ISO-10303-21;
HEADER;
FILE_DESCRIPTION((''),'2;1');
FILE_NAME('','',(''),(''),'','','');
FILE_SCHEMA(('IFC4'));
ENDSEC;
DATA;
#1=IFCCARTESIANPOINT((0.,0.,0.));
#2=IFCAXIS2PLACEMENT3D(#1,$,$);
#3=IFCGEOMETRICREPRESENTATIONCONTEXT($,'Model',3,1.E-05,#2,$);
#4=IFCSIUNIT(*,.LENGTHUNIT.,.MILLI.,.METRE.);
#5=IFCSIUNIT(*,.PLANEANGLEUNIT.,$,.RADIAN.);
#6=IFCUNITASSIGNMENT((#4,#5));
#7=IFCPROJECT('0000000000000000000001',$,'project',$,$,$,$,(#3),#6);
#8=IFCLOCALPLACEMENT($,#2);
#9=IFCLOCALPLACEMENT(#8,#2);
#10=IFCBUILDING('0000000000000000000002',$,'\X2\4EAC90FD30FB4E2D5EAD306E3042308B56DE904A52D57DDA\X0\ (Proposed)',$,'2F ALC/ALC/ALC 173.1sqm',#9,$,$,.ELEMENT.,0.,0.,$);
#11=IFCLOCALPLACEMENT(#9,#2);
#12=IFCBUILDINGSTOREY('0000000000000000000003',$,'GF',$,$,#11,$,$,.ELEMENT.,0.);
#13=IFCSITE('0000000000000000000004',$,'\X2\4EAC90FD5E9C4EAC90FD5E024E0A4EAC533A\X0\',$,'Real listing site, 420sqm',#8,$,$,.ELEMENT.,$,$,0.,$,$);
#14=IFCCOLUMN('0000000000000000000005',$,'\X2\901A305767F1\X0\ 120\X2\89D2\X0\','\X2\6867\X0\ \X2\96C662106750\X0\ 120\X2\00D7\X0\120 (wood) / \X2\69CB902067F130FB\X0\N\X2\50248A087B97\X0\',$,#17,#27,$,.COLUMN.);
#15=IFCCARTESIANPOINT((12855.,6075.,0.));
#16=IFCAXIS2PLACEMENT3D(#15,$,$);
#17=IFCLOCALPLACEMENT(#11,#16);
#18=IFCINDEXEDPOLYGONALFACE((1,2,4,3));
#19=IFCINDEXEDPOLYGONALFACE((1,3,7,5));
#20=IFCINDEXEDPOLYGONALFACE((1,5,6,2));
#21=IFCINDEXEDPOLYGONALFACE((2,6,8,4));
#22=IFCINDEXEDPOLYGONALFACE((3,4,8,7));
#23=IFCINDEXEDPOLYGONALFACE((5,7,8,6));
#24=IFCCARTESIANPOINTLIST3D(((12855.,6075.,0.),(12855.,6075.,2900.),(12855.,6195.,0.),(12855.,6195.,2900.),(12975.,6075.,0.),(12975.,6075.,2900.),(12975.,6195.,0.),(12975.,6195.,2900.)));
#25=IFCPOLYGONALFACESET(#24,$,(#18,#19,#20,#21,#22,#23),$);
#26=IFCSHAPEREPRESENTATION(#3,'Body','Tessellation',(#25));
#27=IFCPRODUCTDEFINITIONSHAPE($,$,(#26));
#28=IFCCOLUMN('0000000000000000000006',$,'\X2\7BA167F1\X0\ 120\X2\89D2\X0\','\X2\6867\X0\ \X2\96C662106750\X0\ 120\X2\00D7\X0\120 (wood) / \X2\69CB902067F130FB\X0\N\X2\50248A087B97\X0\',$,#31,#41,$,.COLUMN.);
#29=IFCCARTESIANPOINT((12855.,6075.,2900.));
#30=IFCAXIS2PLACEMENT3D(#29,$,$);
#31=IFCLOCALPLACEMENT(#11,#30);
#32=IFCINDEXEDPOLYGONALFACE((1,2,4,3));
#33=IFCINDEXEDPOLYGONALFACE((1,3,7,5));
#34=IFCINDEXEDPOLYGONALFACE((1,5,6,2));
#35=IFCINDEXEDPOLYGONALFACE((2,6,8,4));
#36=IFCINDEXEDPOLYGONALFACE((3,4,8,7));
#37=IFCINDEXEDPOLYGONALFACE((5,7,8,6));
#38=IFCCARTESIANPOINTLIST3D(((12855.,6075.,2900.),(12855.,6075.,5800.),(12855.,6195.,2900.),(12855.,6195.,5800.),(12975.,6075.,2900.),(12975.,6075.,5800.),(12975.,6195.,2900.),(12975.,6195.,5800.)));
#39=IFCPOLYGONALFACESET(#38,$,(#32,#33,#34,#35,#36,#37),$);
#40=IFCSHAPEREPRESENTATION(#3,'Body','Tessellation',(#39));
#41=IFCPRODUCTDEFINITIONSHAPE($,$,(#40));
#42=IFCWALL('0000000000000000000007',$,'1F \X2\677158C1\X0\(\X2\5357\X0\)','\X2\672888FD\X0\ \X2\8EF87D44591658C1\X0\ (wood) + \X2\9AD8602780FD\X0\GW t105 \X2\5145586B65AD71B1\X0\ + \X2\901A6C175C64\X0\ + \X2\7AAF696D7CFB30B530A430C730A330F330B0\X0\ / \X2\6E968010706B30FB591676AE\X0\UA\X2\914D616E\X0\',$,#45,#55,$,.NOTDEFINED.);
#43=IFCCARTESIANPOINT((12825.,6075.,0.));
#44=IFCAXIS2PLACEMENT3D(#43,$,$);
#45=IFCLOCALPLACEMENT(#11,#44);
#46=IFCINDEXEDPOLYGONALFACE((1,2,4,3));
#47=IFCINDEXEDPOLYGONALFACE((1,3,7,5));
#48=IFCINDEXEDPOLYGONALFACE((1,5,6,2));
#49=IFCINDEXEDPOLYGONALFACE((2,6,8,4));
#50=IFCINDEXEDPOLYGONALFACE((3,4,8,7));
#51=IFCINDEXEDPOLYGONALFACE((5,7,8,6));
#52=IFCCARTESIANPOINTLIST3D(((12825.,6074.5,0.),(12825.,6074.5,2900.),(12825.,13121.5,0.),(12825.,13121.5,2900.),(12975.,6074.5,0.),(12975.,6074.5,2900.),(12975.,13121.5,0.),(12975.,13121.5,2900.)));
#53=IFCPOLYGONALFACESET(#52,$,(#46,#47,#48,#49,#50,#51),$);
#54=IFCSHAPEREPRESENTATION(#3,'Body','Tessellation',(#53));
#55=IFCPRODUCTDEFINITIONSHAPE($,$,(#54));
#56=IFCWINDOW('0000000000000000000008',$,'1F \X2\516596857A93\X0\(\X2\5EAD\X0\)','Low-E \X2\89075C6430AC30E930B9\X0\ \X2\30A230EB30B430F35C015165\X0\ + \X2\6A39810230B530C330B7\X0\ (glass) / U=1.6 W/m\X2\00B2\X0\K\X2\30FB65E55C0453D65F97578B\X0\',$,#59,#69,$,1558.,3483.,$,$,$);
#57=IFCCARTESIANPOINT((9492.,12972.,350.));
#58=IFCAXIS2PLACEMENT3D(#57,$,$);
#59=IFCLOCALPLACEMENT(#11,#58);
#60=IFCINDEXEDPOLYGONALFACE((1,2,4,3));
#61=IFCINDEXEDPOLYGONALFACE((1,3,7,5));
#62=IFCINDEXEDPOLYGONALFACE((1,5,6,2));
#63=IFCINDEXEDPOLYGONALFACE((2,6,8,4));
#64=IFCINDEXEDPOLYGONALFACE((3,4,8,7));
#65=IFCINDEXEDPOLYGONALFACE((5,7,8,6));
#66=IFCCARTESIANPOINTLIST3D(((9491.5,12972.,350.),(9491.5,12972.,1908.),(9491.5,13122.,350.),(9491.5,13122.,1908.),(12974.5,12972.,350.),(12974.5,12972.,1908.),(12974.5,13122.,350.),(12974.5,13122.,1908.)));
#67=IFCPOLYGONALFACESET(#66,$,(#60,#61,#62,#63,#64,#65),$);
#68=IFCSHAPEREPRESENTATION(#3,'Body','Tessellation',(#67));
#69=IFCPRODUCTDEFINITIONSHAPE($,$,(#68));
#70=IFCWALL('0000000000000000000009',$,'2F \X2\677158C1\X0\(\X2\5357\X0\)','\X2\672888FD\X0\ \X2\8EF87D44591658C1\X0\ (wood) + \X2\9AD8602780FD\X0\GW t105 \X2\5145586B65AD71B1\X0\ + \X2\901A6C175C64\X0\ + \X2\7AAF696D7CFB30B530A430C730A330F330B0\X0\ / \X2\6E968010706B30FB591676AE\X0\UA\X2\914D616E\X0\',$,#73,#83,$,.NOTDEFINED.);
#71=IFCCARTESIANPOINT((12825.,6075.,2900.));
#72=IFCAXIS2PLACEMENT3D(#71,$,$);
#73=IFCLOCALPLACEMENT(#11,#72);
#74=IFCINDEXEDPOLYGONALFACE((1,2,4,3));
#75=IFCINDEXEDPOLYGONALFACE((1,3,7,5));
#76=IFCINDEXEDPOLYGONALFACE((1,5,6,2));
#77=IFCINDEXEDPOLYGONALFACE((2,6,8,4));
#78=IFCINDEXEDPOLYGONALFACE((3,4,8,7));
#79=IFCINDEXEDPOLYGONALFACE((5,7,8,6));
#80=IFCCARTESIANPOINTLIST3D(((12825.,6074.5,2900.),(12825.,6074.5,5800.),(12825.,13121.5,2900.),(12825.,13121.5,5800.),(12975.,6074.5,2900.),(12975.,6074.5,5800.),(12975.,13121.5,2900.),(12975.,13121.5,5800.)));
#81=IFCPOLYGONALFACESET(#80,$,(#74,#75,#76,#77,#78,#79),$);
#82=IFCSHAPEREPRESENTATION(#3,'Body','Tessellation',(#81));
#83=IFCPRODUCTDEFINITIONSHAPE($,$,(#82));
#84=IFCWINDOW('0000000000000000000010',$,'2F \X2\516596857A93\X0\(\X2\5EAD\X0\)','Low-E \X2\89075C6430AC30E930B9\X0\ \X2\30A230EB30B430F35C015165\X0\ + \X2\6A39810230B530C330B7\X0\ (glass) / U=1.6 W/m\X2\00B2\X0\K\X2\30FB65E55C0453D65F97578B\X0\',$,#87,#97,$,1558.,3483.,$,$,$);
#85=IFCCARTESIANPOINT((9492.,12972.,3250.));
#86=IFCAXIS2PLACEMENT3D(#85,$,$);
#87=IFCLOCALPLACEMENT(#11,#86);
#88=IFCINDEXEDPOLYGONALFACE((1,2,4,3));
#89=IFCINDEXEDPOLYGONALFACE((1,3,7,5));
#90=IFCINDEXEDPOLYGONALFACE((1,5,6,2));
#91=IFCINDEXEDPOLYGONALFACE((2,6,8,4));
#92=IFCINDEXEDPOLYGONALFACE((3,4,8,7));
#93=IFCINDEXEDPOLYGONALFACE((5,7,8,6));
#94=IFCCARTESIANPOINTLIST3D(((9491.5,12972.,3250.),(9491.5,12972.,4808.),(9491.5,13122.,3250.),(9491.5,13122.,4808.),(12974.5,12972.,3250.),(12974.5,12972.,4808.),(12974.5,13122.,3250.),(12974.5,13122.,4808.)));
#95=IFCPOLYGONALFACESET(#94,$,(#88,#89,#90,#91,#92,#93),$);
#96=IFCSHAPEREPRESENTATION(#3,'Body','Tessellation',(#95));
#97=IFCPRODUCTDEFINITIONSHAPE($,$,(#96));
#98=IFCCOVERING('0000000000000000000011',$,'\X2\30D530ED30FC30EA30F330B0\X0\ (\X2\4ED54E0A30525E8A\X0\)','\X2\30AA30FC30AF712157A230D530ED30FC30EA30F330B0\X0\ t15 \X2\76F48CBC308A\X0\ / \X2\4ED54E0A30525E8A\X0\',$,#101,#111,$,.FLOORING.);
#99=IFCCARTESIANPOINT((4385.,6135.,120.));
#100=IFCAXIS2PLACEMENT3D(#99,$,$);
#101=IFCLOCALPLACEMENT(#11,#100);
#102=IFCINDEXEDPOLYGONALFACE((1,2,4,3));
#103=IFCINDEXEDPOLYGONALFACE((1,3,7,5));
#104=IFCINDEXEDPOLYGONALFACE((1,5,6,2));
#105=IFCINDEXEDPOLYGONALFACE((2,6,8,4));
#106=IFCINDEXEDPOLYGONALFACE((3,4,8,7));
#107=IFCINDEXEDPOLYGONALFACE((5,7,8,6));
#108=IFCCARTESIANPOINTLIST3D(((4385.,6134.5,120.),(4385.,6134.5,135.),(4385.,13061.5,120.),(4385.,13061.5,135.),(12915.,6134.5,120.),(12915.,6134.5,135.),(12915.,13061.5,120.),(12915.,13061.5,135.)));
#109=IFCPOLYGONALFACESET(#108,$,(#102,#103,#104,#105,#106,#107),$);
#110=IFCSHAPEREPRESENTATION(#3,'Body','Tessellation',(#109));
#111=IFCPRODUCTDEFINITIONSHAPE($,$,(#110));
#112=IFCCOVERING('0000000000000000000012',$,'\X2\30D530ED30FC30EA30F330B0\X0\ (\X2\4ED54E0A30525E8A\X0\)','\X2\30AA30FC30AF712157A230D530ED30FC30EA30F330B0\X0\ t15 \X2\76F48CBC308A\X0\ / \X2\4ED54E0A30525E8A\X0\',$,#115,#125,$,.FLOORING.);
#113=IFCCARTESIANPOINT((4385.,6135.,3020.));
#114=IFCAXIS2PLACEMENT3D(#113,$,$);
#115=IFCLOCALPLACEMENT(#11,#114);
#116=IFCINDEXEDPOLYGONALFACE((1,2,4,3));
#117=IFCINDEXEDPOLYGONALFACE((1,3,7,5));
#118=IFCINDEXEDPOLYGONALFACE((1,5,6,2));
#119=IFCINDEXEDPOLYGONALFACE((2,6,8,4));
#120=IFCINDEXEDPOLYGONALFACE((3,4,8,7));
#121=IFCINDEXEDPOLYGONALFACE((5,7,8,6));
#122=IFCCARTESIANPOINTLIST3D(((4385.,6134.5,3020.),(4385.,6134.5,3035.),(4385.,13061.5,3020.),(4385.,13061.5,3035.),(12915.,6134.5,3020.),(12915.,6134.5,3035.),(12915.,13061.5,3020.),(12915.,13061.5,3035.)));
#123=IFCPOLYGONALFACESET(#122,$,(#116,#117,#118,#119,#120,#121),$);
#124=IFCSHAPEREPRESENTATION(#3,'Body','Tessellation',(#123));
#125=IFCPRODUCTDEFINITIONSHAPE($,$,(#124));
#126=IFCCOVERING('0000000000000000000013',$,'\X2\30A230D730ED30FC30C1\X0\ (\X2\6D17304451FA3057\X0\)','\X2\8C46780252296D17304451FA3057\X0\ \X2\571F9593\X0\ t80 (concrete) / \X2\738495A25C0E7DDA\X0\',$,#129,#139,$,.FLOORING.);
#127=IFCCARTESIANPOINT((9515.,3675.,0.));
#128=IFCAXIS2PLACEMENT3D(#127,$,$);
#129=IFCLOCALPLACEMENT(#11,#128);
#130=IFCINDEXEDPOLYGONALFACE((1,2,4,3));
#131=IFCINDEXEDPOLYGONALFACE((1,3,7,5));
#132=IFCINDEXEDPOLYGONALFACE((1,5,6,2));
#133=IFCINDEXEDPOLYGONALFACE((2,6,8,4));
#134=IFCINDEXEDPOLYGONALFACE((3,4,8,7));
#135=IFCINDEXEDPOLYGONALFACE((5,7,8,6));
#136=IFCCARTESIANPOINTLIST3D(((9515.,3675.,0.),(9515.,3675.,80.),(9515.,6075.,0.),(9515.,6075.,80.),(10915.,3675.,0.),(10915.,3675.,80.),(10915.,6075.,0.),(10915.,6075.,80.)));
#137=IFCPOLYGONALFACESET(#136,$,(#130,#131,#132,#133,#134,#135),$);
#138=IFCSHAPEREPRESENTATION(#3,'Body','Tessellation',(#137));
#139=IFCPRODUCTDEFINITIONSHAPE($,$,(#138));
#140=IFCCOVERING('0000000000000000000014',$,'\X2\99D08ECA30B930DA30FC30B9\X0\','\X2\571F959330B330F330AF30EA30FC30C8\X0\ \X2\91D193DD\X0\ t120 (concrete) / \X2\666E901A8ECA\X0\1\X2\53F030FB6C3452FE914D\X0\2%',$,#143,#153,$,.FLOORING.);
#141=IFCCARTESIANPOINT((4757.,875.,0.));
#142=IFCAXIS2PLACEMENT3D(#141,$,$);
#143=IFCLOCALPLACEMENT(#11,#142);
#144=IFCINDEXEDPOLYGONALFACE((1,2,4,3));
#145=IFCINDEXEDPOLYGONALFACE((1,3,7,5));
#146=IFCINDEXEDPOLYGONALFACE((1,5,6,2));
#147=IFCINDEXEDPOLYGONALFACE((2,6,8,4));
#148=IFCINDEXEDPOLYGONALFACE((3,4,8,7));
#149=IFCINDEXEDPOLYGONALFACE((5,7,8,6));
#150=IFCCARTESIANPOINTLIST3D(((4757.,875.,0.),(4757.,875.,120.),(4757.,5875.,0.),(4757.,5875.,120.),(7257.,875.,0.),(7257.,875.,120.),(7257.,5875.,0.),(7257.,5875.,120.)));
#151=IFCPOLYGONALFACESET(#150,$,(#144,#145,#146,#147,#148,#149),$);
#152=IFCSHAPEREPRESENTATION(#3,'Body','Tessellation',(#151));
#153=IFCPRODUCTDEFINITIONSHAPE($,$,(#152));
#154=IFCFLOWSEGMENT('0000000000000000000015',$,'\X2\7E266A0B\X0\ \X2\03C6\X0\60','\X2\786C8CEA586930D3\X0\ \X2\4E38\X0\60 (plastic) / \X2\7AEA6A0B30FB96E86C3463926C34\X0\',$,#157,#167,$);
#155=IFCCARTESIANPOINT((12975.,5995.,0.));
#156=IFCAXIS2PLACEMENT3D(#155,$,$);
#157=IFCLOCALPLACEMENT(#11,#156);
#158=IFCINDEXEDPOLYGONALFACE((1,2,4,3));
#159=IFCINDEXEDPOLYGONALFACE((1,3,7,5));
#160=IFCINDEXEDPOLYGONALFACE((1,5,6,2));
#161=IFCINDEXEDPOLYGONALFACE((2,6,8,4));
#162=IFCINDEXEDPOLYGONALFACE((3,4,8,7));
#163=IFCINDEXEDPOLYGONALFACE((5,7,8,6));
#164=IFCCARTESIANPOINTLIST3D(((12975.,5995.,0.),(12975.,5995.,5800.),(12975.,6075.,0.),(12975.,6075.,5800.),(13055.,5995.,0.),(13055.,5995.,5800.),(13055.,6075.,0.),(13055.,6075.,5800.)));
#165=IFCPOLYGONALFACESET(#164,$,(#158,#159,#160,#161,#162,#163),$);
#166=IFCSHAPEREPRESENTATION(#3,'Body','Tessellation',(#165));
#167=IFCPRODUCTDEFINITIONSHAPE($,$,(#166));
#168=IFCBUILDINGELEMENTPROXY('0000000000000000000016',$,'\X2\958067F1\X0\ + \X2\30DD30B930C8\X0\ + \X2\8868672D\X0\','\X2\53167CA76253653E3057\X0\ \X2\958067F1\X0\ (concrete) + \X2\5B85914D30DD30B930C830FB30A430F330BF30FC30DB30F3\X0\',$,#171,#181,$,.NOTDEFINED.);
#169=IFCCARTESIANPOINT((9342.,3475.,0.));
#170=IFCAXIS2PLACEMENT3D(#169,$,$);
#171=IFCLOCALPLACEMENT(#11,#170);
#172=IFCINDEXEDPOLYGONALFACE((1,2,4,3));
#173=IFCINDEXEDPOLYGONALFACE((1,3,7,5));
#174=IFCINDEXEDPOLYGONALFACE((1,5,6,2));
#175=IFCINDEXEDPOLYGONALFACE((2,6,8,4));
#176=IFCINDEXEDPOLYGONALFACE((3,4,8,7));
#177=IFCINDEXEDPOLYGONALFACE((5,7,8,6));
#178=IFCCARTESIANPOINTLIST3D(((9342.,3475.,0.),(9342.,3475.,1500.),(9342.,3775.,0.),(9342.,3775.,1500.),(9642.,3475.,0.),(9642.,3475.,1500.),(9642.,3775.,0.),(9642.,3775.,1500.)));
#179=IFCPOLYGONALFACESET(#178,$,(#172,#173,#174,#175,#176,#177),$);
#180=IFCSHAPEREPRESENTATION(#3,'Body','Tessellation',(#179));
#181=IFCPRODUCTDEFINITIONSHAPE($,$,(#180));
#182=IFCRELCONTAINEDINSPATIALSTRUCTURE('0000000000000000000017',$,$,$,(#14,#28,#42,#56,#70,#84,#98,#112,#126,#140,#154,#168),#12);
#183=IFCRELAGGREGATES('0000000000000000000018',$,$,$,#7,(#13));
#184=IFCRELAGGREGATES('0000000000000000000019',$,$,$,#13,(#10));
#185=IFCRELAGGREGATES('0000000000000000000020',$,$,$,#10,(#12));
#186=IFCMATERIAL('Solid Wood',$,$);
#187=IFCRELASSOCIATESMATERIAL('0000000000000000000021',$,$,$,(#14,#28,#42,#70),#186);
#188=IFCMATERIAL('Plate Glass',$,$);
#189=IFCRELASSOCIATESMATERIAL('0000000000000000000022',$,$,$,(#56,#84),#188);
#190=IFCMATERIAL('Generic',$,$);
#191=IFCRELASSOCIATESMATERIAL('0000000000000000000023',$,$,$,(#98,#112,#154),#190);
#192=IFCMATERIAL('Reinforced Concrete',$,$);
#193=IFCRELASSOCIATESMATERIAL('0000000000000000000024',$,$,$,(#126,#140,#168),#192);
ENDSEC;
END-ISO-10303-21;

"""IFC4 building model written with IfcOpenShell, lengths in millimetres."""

from ifc_helpers import new_model, si_unit, frame, frame_2d, origin, place, context, project, spatial, rectangle, extrude, material, element, fill, save


model = new_model("IFC4")

# Units and contexts
model_context = context("Model", 3, precision=1e-05, world=origin())
ifc_project = project(units=[si_unit("LENGTHUNIT", "METRE", prefix="MILLI"), si_unit("PLANEANGLEUNIT", "RADIAN")], contexts=[model_context])

# Site, building, storey
site_placement = place(None, origin())
site = spatial("IfcSite", under=ifc_project, at=site_placement, Name="京都府京都市上京区", ObjectType="Real listing site, 420sqm", CompositionType="ELEMENT", RefElevation=0.0)
building_placement = place(site_placement, origin())
building = spatial("IfcBuilding", under=site, at=building_placement, Name="京都・中庭のある回遊動線 (Proposed)", ObjectType="2F ALC/ALC/ALC 173.1sqm", CompositionType="ELEMENT", ElevationOfRefHeight=0.0, ElevationOfTerrain=0.0)
storey_placement = place(building_placement, origin())
storey = spatial("IfcBuildingStorey", under=building, at=storey_placement, Name="GF", CompositionType="ELEMENT", Elevation=0.0)

# Columns
ifc_material_1 = material(Name="Solid Wood")
column_1_placement = place(storey_placement, frame((12855.0, 6075.0, 0.0)))
element("IfcColumn", 1, at=column_1_placement, inside=storey, material=ifc_material_1, Name="通し柱 120角", Description="桧 集成材 120×120 (wood) / 構造柱・N値計算", PredefinedType="COLUMN", context=model_context, shape_type="SweptSolid", body=[
    extrude(rectangle(XDim=120.0, YDim=120.0, at=frame_2d((60.0, 60.0))), frame((12855.0, 6075.0, 0.0)), (0.0, 0.0, 1.0), 2900.0),
])
column_2_placement = place(storey_placement, frame((12855.0, 6075.0, 2900.0)))
element("IfcColumn", 2, at=column_2_placement, inside=storey, material=ifc_material_1, Name="管柱 120角", Description="桧 集成材 120×120 (wood) / 構造柱・N値計算", PredefinedType="COLUMN", context=model_context, shape_type="SweptSolid", body=[
    extrude(rectangle(XDim=120.0, YDim=120.0, at=frame_2d((60.0, 60.0))), frame((12855.0, 6075.0, 2900.0)), (0.0, 0.0, 1.0), 2900.0),
])

# Wall, opening, window
wall_1_placement = place(storey_placement, frame((12825.0, 6075.0, 0.0)))
wall_1 = element("IfcWall", 3, at=wall_1_placement, inside=storey, material=ifc_material_1, Name="1F 東壁(南)", Description="木製 軸組外壁 (wood) + 高性能GW t105 充填断熱 + 通気層 + 窯業系サイディング / 準耐火・外皮UA配慮", PredefinedType="NOTDEFINED", context=model_context, shape_type="SweptSolid", body=[
    extrude(rectangle(XDim=150.0, YDim=7047.0, at=frame_2d((75.0, 3523.0))), frame((12825.0, 6075.0, 0.0)), (0.0, 0.0, 1.0), 2900.0),
])
opening_1_placement = place(storey_placement, frame((9492.0, 12972.0, 350.0)))
opening_1 = element("IfcOpeningElement", 4, at=opening_1_placement, cuts=wall_1, PredefinedType="NOTDEFINED", context=model_context, shape_type="SweptSolid", body=[
    extrude(rectangle(XDim=3483.0, YDim=150.0, at=frame_2d((1741.0, 75.0))), frame((9492.0, 12972.0, 350.0)), (0.0, 0.0, 1.0), 1558.0),
])
ifc_material_2 = material(Name="Plate Glass")
window_1_placement = place(storey_placement, frame((9492.0, 12972.0, 350.0)))
window_1 = element("IfcWindow", 5, at=window_1_placement, inside=storey, material=ifc_material_2, Name="1F 入隅窓(庭)", Description="Low-E 複層ガラス アルゴン封入 + 樹脂サッシ (glass) / U=1.6 W/m²K・日射取得型", OverallHeight=1558.0, OverallWidth=3483.0, context=model_context, shape_type="SweptSolid", body=[
    extrude(rectangle(XDim=3483.0, YDim=150.0, at=frame_2d((1741.0, 75.0))), frame((9492.0, 12972.0, 350.0)), (0.0, 0.0, 1.0), 1558.0),
])
fill(opening_1, window_1)

# Wall, opening, window
wall_2_placement = place(storey_placement, frame((12825.0, 6075.0, 2900.0)))
wall_2 = element("IfcWall", 6, at=wall_2_placement, inside=storey, material=ifc_material_1, Name="2F 東壁(南)", Description="木製 軸組外壁 (wood) + 高性能GW t105 充填断熱 + 通気層 + 窯業系サイディング / 準耐火・外皮UA配慮", PredefinedType="NOTDEFINED", context=model_context, shape_type="SweptSolid", body=[
    extrude(rectangle(XDim=150.0, YDim=7047.0, at=frame_2d((75.0, 3523.0))), frame((12825.0, 6075.0, 2900.0)), (0.0, 0.0, 1.0), 2900.0),
])
opening_2_placement = place(storey_placement, frame((9492.0, 12972.0, 3250.0)))
opening_2 = element("IfcOpeningElement", 7, at=opening_2_placement, cuts=wall_2, PredefinedType="NOTDEFINED", context=model_context, shape_type="SweptSolid", body=[
    extrude(rectangle(XDim=3483.0, YDim=150.0, at=frame_2d((1741.0, 75.0))), frame((9492.0, 12972.0, 3250.0)), (0.0, 0.0, 1.0), 1558.0),
])
window_2_placement = place(storey_placement, frame((9492.0, 12972.0, 3250.0)))
window_2 = element("IfcWindow", 8, at=window_2_placement, inside=storey, material=ifc_material_2, Name="2F 入隅窓(庭)", Description="Low-E 複層ガラス アルゴン封入 + 樹脂サッシ (glass) / U=1.6 W/m²K・日射取得型", OverallHeight=1558.0, OverallWidth=3483.0, context=model_context, shape_type="SweptSolid", body=[
    extrude(rectangle(XDim=3483.0, YDim=150.0, at=frame_2d((1741.0, 75.0))), frame((9492.0, 12972.0, 3250.0)), (0.0, 0.0, 1.0), 1558.0),
])
fill(opening_2, window_2)

# Coverings
ifc_material_3 = material(Name="Generic")
covering_1_placement = place(storey_placement, frame((4385.0, 6135.0, 120.0)))
element("IfcCovering", 9, at=covering_1_placement, inside=storey, material=ifc_material_3, Name="フローリング (仕上げ床)", Description="オーク無垢フローリング t15 直貼り / 仕上げ床", PredefinedType="FLOORING", context=model_context, shape_type="SweptSolid", body=[
    extrude(rectangle(XDim=8530.0, YDim=6927.0, at=frame_2d((4265.0, 3463.0))), frame((4385.0, 6135.0, 120.0)), (0.0, 0.0, 1.0), 15.0),
])
covering_2_placement = place(storey_placement, frame((4385.0, 6135.0, 3020.0)))
element("IfcCovering", 10, at=covering_2_placement, inside=storey, material=ifc_material_3, Name="フローリング (仕上げ床)", Description="オーク無垢フローリング t15 直貼り / 仕上げ床", PredefinedType="FLOORING", context=model_context, shape_type="SweptSolid", body=[
    extrude(rectangle(XDim=8530.0, YDim=6927.0, at=frame_2d((4265.0, 3463.0))), frame((4385.0, 6135.0, 3020.0)), (0.0, 0.0, 1.0), 15.0),
])
ifc_material_4 = material(Name="Reinforced Concrete")
covering_3_placement = place(storey_placement, frame((9515.0, 3675.0, 0.0)))
element("IfcCovering", 11, at=covering_3_placement, inside=storey, material=ifc_material_4, Name="アプローチ (洗い出し)", Description="豆砂利洗い出し 土間 t80 (concrete) / 玄関導線", PredefinedType="FLOORING", context=model_context, shape_type="SweptSolid", body=[
    extrude(rectangle(XDim=1400.0, YDim=2400.0, at=frame_2d((700.0, 1200.0))), frame((9515.0, 3675.0, 0.0)), (0.0, 0.0, 1.0), 80.0),
])
covering_4_placement = place(storey_placement, frame((4757.0, 875.0, 0.0)))
element("IfcCovering", 12, at=covering_4_placement, inside=storey, material=ifc_material_4, Name="駐車スペース", Description="土間コンクリート 金鏝 t120 (concrete) / 普通車1台・水勾配2%", PredefinedType="FLOORING", context=model_context, shape_type="SweptSolid", body=[
    extrude(rectangle(XDim=2500.0, YDim=5000.0, at=frame_2d((1250.0, 2500.0))), frame((4757.0, 875.0, 0.0)), (0.0, 0.0, 1.0), 120.0),
])

# Flow segment
flow_segment_placement = place(storey_placement, frame((12975.0, 5995.0, 0.0)))
element("IfcFlowSegment", 13, at=flow_segment_placement, inside=storey, material=ifc_material_3, Name="縦樋 φ60", Description="硬質塩ビ 丸60 (plastic) / 竪樋・雨水排水", context=model_context, shape_type="SweptSolid", body=[
    extrude(rectangle(XDim=80.0, YDim=80.0, at=frame_2d((40.0, 40.0))), frame((12975.0, 5995.0, 0.0)), (0.0, 0.0, 1.0), 5800.0),
])

# Building element proxy
proxy_placement = place(storey_placement, frame((9342.0, 3475.0, 0.0)))
element("IfcBuildingElementProxy", 14, at=proxy_placement, inside=storey, material=ifc_material_4, Name="門柱 + ポスト + 表札", Description="化粧打放し 門柱 (concrete) + 宅配ポスト・インターホン", PredefinedType="NOTDEFINED", context=model_context, shape_type="SweptSolid", body=[
    extrude(rectangle(XDim=300.0, YDim=300.0, at=frame_2d((150.0, 150.0))), frame((9342.0, 3475.0, 0.0)), (0.0, 0.0, 1.0), 1500.0),
])

save(model, "model.ifc")
